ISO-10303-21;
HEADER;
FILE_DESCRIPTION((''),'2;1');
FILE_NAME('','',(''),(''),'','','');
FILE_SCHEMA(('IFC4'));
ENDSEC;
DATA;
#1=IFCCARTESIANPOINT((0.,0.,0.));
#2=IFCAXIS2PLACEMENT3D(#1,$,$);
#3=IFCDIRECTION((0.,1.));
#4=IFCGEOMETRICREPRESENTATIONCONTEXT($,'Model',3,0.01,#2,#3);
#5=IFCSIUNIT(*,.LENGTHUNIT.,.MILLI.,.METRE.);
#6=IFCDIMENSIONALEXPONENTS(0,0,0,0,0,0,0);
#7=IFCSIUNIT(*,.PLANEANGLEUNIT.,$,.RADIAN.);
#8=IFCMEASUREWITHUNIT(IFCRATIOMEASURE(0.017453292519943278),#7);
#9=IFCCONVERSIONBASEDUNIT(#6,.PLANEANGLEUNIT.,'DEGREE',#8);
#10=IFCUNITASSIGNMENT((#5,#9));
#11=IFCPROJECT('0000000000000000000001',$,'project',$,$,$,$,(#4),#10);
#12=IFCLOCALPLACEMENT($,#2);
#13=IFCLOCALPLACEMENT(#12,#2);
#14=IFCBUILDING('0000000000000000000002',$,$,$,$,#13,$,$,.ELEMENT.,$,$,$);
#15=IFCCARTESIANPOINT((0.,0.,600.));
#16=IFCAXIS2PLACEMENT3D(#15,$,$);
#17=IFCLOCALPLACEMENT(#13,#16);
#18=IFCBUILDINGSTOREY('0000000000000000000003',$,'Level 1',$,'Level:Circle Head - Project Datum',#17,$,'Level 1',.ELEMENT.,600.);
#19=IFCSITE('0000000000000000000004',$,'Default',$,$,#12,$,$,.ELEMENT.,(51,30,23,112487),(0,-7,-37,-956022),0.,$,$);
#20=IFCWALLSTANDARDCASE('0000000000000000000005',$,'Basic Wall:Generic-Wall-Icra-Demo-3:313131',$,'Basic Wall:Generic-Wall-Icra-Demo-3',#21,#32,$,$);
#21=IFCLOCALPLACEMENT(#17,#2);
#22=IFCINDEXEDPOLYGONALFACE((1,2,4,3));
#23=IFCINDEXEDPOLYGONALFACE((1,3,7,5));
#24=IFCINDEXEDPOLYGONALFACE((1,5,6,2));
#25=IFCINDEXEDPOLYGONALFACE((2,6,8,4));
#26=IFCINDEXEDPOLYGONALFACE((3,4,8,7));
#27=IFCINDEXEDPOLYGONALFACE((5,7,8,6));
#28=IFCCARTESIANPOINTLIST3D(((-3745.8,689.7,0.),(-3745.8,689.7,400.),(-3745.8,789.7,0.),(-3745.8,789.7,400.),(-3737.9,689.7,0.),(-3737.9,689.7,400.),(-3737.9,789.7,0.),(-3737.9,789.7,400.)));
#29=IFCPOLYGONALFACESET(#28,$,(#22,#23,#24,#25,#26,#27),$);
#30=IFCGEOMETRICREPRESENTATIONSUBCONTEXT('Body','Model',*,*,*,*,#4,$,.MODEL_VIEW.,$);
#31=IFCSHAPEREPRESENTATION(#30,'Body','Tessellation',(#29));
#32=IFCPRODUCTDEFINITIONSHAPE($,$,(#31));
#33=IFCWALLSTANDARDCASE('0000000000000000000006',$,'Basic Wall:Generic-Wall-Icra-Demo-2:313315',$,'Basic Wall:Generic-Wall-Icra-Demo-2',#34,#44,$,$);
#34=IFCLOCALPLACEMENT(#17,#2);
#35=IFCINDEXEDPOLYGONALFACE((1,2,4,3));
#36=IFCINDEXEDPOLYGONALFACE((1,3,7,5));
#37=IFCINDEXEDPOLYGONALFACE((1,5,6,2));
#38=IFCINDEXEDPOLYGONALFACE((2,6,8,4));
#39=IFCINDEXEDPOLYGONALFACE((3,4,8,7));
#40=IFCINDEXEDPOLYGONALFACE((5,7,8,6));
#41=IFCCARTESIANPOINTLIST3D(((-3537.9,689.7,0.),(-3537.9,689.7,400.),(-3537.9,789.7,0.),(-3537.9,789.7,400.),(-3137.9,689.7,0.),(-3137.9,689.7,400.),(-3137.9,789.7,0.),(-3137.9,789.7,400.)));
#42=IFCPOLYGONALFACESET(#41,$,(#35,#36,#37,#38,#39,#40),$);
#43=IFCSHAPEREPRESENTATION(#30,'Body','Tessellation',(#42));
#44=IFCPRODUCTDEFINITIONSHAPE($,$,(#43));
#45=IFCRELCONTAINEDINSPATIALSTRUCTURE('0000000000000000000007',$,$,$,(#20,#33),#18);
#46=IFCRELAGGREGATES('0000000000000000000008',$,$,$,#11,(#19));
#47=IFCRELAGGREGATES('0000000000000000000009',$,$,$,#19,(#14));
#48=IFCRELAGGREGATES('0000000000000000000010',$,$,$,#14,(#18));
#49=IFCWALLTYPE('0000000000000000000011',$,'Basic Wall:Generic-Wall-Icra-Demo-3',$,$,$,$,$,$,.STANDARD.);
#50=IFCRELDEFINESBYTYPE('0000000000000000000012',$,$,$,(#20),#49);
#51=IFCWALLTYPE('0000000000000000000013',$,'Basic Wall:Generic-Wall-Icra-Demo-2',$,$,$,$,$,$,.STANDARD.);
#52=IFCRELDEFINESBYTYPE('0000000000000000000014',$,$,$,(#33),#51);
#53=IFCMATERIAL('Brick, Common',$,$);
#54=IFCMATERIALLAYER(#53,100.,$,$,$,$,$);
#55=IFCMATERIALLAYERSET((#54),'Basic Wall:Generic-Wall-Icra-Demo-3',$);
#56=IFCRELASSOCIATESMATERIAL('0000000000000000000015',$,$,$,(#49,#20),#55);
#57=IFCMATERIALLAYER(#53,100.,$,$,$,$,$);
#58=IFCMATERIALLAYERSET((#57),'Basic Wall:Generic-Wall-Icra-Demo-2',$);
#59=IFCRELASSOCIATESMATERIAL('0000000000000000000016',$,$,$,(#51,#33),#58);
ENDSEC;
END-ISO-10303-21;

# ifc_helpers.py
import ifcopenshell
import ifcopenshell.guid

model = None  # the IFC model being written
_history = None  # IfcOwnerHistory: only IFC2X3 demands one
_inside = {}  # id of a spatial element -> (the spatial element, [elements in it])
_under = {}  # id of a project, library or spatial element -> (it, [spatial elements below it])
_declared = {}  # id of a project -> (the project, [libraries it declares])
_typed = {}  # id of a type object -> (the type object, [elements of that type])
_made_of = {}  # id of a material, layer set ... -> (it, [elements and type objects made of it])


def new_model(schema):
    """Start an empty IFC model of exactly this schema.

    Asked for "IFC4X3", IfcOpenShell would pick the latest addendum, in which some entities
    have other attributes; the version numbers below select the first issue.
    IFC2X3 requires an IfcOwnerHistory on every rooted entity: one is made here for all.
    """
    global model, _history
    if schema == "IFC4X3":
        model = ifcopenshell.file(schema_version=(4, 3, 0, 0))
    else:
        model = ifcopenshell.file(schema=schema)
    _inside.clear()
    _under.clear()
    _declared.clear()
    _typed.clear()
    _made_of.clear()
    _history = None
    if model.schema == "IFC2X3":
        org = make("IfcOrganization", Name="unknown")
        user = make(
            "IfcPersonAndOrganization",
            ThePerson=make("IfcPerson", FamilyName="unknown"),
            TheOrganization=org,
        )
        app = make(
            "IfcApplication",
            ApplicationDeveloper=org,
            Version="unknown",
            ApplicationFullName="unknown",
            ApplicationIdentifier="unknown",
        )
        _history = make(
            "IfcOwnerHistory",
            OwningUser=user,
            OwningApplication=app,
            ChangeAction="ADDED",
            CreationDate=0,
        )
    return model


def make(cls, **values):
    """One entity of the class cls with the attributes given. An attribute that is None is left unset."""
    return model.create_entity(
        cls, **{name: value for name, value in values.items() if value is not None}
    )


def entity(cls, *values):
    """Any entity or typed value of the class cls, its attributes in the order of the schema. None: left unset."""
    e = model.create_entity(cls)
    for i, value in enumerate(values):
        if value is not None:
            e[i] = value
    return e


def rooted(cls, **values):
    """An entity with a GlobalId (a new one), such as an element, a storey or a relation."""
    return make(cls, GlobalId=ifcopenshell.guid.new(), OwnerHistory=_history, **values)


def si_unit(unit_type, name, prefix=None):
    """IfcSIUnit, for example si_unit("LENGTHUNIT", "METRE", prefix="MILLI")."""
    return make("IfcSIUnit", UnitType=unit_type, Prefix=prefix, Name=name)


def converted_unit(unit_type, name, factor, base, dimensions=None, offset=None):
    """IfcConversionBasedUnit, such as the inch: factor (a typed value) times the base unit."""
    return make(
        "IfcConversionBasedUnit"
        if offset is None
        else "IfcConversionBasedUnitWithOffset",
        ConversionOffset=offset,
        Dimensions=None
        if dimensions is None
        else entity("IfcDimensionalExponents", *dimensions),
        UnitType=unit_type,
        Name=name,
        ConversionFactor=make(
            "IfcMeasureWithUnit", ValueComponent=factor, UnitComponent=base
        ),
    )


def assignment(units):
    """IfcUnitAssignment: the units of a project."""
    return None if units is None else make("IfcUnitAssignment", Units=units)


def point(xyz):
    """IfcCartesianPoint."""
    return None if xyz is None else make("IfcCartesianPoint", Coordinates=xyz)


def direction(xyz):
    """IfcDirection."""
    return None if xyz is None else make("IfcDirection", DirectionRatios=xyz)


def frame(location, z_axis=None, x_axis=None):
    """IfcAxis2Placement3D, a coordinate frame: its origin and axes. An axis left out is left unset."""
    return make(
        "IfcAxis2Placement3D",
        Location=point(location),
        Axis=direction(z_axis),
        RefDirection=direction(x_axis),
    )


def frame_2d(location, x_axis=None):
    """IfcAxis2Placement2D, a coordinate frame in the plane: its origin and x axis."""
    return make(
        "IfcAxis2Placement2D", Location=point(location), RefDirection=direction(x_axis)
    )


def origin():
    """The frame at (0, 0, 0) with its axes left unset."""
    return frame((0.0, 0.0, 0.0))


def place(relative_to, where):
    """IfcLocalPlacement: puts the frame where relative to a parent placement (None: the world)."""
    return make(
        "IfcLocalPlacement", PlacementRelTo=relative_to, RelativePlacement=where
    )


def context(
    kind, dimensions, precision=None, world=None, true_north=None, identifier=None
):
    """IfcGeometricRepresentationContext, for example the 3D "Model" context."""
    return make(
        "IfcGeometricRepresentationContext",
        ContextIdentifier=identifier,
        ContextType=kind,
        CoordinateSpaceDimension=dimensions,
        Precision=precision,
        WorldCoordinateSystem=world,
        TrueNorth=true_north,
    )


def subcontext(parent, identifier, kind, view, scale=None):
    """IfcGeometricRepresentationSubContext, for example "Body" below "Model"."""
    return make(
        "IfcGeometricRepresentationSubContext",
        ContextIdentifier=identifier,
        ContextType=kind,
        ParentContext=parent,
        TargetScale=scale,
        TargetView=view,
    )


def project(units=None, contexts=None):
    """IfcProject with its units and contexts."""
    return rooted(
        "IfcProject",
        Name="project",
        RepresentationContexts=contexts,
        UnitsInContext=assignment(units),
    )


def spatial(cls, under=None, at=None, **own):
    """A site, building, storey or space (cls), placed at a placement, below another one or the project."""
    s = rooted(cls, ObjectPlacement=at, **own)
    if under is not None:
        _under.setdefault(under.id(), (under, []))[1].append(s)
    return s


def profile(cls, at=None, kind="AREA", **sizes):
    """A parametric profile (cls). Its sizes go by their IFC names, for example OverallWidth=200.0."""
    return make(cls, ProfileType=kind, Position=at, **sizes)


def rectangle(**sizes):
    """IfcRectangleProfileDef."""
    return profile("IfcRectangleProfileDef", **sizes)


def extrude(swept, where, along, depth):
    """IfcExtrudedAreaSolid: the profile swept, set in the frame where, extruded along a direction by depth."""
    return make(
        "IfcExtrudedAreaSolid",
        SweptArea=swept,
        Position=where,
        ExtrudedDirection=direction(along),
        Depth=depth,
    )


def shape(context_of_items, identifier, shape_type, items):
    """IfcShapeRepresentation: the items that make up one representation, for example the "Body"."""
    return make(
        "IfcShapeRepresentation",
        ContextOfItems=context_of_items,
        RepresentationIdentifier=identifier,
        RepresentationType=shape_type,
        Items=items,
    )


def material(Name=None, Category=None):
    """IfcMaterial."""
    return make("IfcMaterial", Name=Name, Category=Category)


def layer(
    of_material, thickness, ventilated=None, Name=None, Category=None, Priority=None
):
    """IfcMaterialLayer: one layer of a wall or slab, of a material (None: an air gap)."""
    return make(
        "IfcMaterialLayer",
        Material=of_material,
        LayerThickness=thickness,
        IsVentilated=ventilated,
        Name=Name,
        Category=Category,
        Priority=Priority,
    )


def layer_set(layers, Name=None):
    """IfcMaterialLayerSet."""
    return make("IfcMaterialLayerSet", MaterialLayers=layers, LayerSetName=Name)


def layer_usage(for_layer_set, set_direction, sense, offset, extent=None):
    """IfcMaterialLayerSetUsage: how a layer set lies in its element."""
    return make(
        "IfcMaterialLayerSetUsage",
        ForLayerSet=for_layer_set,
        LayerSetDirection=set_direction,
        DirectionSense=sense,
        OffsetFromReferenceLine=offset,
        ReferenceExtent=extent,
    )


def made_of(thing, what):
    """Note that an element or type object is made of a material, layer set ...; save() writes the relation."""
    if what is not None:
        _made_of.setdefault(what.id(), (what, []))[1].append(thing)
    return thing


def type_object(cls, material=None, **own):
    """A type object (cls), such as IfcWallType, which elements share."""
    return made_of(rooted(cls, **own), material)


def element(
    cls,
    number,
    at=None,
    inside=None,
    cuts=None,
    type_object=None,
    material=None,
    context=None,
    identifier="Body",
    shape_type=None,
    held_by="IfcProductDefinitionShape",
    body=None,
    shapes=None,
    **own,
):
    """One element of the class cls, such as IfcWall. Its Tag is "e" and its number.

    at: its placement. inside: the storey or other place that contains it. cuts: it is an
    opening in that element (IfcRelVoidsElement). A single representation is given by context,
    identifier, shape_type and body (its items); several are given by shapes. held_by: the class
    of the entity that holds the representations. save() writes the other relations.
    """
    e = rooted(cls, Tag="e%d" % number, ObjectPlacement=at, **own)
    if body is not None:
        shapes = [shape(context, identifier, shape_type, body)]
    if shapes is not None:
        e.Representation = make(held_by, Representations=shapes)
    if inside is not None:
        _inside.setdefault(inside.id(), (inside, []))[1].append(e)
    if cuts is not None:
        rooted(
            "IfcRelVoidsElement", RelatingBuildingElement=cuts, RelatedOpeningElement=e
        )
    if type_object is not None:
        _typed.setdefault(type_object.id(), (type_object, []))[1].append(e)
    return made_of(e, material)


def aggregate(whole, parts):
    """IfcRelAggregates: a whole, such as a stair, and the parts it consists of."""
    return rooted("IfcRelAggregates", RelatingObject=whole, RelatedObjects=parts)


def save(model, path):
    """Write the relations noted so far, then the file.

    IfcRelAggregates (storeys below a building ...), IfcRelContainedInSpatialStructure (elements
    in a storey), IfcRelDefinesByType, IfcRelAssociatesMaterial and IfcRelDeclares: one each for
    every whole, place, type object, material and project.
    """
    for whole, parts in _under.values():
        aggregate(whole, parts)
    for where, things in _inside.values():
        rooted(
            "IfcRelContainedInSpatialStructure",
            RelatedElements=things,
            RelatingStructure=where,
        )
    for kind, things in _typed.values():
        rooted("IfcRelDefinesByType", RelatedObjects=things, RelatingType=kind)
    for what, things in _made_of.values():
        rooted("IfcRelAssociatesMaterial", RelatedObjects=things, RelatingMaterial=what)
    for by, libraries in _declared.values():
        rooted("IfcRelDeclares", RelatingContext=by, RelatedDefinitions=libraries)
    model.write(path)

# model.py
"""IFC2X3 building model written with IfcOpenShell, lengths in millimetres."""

from ifc_helpers import new_model, entity, si_unit, converted_unit, direction, frame, frame_2d, origin, place, context, subcontext, project, spatial, rectangle, extrude, material, layer, layer_set, layer_usage, type_object, element, save


model = new_model("IFC2X3")

# Units and contexts
model_context = context("Model", 3, precision=0.01, world=origin(), true_north=direction((0.0, 1.0)))
body_context = subcontext(model_context, "Body", "Model", "MODEL_VIEW")
ifc_project = project(units=[si_unit("LENGTHUNIT", "METRE", prefix="MILLI"), converted_unit("PLANEANGLEUNIT", "DEGREE", entity("IfcRatioMeasure", 0.017453292519943278), si_unit("PLANEANGLEUNIT", "RADIAN"), dimensions=[0, 0, 0, 0, 0, 0, 0])], contexts=[model_context])

# Site, building, storey
site_placement = place(None, origin())
site = spatial("IfcSite", under=ifc_project, at=site_placement, Name="Default", CompositionType="ELEMENT", RefLatitude=(51, 30, 23, 112487), RefLongitude=(0, -7, -37, -956022), RefElevation=0.0)
building_placement = place(site_placement, origin())
building = spatial("IfcBuilding", under=site, at=building_placement, CompositionType="ELEMENT")
storey_placement = place(building_placement, frame((0.0, 0.0, 600.0)))
storey = spatial("IfcBuildingStorey", under=building, at=storey_placement, Name="Level 1", ObjectType="Level:Circle Head - Project Datum", LongName="Level 1", CompositionType="ELEMENT", Elevation=600.0)

# Wall, opening
ifc_material = material(Name="Brick, Common")
ifc_layer_1 = layer(ifc_material, 100.0)
ifc_layer_set_1 = layer_set([ifc_layer_1], Name="Basic Wall:Generic-Wall-Icra-Demo-3")
ifc_layer_usage_1 = layer_usage(ifc_layer_set_1, "AXIS2", "NEGATIVE", 50.0)
wall_type_1 = type_object("IfcWallType", Name="Basic Wall:Generic-Wall-Icra-Demo-3", PredefinedType="STANDARD", material=ifc_layer_set_1)
wall_1_placement = place(storey_placement, frame((-3745.8, 739.7, 0.0)))
wall_1 = element("IfcWallStandardCase", 1, at=wall_1_placement, inside=storey, type_object=wall_type_1, material=ifc_layer_usage_1, Name="Basic Wall:Generic-Wall-Icra-Demo-3:313131", ObjectType="Basic Wall:Generic-Wall-Icra-Demo-3", context=body_context, shape_type="SweptSolid", body=[
    extrude(rectangle(XDim=100.0, YDim=7.8, at=frame_2d((3.9, 0.0), x_axis=(0.0, -1.0))), origin(), (0.0, 0.0, 1.0), 400.0),
])
opening_placement = place(wall_1_placement, frame((-400.0, -50.0, 0.0)))
element("IfcOpeningElement", 2, at=opening_placement, cuts=wall_1, ObjectType="Opening", context=body_context, shape_type="SweptSolid", body=[
    extrude(rectangle(XDim=400.0, YDim=400.0, at=frame_2d((200.0, 200.0), x_axis=(1.0, 0.0))), frame((0.0, 0.0, 0.0), z_axis=(0.0, 1.0, 0.0), x_axis=(0.0, 0.0, 1.0)), (0.0, 0.0, 1.0), 100.0),
])

# Wall
ifc_layer_2 = layer(ifc_material, 100.0)
ifc_layer_set_2 = layer_set([ifc_layer_2], Name="Basic Wall:Generic-Wall-Icra-Demo-2")
ifc_layer_usage_2 = layer_usage(ifc_layer_set_2, "AXIS2", "NEGATIVE", 50.0)
wall_type_2 = type_object("IfcWallType", Name="Basic Wall:Generic-Wall-Icra-Demo-2", PredefinedType="STANDARD", material=ifc_layer_set_2)
wall_2_placement = place(storey_placement, frame((-3537.9, 739.7, 0.0)))
element("IfcWallStandardCase", 3, at=wall_2_placement, inside=storey, type_object=wall_type_2, material=ifc_layer_usage_2, Name="Basic Wall:Generic-Wall-Icra-Demo-2:313315", ObjectType="Basic Wall:Generic-Wall-Icra-Demo-2", context=body_context, shape_type="SweptSolid", body=[
    extrude(rectangle(XDim=400.0, YDim=100.0, at=frame_2d((200.0, 0.0), x_axis=(-1.0, 0.0))), origin(), (0.0, 0.0, 1.0), 400.0),
])

save(model, "model.ifc")
